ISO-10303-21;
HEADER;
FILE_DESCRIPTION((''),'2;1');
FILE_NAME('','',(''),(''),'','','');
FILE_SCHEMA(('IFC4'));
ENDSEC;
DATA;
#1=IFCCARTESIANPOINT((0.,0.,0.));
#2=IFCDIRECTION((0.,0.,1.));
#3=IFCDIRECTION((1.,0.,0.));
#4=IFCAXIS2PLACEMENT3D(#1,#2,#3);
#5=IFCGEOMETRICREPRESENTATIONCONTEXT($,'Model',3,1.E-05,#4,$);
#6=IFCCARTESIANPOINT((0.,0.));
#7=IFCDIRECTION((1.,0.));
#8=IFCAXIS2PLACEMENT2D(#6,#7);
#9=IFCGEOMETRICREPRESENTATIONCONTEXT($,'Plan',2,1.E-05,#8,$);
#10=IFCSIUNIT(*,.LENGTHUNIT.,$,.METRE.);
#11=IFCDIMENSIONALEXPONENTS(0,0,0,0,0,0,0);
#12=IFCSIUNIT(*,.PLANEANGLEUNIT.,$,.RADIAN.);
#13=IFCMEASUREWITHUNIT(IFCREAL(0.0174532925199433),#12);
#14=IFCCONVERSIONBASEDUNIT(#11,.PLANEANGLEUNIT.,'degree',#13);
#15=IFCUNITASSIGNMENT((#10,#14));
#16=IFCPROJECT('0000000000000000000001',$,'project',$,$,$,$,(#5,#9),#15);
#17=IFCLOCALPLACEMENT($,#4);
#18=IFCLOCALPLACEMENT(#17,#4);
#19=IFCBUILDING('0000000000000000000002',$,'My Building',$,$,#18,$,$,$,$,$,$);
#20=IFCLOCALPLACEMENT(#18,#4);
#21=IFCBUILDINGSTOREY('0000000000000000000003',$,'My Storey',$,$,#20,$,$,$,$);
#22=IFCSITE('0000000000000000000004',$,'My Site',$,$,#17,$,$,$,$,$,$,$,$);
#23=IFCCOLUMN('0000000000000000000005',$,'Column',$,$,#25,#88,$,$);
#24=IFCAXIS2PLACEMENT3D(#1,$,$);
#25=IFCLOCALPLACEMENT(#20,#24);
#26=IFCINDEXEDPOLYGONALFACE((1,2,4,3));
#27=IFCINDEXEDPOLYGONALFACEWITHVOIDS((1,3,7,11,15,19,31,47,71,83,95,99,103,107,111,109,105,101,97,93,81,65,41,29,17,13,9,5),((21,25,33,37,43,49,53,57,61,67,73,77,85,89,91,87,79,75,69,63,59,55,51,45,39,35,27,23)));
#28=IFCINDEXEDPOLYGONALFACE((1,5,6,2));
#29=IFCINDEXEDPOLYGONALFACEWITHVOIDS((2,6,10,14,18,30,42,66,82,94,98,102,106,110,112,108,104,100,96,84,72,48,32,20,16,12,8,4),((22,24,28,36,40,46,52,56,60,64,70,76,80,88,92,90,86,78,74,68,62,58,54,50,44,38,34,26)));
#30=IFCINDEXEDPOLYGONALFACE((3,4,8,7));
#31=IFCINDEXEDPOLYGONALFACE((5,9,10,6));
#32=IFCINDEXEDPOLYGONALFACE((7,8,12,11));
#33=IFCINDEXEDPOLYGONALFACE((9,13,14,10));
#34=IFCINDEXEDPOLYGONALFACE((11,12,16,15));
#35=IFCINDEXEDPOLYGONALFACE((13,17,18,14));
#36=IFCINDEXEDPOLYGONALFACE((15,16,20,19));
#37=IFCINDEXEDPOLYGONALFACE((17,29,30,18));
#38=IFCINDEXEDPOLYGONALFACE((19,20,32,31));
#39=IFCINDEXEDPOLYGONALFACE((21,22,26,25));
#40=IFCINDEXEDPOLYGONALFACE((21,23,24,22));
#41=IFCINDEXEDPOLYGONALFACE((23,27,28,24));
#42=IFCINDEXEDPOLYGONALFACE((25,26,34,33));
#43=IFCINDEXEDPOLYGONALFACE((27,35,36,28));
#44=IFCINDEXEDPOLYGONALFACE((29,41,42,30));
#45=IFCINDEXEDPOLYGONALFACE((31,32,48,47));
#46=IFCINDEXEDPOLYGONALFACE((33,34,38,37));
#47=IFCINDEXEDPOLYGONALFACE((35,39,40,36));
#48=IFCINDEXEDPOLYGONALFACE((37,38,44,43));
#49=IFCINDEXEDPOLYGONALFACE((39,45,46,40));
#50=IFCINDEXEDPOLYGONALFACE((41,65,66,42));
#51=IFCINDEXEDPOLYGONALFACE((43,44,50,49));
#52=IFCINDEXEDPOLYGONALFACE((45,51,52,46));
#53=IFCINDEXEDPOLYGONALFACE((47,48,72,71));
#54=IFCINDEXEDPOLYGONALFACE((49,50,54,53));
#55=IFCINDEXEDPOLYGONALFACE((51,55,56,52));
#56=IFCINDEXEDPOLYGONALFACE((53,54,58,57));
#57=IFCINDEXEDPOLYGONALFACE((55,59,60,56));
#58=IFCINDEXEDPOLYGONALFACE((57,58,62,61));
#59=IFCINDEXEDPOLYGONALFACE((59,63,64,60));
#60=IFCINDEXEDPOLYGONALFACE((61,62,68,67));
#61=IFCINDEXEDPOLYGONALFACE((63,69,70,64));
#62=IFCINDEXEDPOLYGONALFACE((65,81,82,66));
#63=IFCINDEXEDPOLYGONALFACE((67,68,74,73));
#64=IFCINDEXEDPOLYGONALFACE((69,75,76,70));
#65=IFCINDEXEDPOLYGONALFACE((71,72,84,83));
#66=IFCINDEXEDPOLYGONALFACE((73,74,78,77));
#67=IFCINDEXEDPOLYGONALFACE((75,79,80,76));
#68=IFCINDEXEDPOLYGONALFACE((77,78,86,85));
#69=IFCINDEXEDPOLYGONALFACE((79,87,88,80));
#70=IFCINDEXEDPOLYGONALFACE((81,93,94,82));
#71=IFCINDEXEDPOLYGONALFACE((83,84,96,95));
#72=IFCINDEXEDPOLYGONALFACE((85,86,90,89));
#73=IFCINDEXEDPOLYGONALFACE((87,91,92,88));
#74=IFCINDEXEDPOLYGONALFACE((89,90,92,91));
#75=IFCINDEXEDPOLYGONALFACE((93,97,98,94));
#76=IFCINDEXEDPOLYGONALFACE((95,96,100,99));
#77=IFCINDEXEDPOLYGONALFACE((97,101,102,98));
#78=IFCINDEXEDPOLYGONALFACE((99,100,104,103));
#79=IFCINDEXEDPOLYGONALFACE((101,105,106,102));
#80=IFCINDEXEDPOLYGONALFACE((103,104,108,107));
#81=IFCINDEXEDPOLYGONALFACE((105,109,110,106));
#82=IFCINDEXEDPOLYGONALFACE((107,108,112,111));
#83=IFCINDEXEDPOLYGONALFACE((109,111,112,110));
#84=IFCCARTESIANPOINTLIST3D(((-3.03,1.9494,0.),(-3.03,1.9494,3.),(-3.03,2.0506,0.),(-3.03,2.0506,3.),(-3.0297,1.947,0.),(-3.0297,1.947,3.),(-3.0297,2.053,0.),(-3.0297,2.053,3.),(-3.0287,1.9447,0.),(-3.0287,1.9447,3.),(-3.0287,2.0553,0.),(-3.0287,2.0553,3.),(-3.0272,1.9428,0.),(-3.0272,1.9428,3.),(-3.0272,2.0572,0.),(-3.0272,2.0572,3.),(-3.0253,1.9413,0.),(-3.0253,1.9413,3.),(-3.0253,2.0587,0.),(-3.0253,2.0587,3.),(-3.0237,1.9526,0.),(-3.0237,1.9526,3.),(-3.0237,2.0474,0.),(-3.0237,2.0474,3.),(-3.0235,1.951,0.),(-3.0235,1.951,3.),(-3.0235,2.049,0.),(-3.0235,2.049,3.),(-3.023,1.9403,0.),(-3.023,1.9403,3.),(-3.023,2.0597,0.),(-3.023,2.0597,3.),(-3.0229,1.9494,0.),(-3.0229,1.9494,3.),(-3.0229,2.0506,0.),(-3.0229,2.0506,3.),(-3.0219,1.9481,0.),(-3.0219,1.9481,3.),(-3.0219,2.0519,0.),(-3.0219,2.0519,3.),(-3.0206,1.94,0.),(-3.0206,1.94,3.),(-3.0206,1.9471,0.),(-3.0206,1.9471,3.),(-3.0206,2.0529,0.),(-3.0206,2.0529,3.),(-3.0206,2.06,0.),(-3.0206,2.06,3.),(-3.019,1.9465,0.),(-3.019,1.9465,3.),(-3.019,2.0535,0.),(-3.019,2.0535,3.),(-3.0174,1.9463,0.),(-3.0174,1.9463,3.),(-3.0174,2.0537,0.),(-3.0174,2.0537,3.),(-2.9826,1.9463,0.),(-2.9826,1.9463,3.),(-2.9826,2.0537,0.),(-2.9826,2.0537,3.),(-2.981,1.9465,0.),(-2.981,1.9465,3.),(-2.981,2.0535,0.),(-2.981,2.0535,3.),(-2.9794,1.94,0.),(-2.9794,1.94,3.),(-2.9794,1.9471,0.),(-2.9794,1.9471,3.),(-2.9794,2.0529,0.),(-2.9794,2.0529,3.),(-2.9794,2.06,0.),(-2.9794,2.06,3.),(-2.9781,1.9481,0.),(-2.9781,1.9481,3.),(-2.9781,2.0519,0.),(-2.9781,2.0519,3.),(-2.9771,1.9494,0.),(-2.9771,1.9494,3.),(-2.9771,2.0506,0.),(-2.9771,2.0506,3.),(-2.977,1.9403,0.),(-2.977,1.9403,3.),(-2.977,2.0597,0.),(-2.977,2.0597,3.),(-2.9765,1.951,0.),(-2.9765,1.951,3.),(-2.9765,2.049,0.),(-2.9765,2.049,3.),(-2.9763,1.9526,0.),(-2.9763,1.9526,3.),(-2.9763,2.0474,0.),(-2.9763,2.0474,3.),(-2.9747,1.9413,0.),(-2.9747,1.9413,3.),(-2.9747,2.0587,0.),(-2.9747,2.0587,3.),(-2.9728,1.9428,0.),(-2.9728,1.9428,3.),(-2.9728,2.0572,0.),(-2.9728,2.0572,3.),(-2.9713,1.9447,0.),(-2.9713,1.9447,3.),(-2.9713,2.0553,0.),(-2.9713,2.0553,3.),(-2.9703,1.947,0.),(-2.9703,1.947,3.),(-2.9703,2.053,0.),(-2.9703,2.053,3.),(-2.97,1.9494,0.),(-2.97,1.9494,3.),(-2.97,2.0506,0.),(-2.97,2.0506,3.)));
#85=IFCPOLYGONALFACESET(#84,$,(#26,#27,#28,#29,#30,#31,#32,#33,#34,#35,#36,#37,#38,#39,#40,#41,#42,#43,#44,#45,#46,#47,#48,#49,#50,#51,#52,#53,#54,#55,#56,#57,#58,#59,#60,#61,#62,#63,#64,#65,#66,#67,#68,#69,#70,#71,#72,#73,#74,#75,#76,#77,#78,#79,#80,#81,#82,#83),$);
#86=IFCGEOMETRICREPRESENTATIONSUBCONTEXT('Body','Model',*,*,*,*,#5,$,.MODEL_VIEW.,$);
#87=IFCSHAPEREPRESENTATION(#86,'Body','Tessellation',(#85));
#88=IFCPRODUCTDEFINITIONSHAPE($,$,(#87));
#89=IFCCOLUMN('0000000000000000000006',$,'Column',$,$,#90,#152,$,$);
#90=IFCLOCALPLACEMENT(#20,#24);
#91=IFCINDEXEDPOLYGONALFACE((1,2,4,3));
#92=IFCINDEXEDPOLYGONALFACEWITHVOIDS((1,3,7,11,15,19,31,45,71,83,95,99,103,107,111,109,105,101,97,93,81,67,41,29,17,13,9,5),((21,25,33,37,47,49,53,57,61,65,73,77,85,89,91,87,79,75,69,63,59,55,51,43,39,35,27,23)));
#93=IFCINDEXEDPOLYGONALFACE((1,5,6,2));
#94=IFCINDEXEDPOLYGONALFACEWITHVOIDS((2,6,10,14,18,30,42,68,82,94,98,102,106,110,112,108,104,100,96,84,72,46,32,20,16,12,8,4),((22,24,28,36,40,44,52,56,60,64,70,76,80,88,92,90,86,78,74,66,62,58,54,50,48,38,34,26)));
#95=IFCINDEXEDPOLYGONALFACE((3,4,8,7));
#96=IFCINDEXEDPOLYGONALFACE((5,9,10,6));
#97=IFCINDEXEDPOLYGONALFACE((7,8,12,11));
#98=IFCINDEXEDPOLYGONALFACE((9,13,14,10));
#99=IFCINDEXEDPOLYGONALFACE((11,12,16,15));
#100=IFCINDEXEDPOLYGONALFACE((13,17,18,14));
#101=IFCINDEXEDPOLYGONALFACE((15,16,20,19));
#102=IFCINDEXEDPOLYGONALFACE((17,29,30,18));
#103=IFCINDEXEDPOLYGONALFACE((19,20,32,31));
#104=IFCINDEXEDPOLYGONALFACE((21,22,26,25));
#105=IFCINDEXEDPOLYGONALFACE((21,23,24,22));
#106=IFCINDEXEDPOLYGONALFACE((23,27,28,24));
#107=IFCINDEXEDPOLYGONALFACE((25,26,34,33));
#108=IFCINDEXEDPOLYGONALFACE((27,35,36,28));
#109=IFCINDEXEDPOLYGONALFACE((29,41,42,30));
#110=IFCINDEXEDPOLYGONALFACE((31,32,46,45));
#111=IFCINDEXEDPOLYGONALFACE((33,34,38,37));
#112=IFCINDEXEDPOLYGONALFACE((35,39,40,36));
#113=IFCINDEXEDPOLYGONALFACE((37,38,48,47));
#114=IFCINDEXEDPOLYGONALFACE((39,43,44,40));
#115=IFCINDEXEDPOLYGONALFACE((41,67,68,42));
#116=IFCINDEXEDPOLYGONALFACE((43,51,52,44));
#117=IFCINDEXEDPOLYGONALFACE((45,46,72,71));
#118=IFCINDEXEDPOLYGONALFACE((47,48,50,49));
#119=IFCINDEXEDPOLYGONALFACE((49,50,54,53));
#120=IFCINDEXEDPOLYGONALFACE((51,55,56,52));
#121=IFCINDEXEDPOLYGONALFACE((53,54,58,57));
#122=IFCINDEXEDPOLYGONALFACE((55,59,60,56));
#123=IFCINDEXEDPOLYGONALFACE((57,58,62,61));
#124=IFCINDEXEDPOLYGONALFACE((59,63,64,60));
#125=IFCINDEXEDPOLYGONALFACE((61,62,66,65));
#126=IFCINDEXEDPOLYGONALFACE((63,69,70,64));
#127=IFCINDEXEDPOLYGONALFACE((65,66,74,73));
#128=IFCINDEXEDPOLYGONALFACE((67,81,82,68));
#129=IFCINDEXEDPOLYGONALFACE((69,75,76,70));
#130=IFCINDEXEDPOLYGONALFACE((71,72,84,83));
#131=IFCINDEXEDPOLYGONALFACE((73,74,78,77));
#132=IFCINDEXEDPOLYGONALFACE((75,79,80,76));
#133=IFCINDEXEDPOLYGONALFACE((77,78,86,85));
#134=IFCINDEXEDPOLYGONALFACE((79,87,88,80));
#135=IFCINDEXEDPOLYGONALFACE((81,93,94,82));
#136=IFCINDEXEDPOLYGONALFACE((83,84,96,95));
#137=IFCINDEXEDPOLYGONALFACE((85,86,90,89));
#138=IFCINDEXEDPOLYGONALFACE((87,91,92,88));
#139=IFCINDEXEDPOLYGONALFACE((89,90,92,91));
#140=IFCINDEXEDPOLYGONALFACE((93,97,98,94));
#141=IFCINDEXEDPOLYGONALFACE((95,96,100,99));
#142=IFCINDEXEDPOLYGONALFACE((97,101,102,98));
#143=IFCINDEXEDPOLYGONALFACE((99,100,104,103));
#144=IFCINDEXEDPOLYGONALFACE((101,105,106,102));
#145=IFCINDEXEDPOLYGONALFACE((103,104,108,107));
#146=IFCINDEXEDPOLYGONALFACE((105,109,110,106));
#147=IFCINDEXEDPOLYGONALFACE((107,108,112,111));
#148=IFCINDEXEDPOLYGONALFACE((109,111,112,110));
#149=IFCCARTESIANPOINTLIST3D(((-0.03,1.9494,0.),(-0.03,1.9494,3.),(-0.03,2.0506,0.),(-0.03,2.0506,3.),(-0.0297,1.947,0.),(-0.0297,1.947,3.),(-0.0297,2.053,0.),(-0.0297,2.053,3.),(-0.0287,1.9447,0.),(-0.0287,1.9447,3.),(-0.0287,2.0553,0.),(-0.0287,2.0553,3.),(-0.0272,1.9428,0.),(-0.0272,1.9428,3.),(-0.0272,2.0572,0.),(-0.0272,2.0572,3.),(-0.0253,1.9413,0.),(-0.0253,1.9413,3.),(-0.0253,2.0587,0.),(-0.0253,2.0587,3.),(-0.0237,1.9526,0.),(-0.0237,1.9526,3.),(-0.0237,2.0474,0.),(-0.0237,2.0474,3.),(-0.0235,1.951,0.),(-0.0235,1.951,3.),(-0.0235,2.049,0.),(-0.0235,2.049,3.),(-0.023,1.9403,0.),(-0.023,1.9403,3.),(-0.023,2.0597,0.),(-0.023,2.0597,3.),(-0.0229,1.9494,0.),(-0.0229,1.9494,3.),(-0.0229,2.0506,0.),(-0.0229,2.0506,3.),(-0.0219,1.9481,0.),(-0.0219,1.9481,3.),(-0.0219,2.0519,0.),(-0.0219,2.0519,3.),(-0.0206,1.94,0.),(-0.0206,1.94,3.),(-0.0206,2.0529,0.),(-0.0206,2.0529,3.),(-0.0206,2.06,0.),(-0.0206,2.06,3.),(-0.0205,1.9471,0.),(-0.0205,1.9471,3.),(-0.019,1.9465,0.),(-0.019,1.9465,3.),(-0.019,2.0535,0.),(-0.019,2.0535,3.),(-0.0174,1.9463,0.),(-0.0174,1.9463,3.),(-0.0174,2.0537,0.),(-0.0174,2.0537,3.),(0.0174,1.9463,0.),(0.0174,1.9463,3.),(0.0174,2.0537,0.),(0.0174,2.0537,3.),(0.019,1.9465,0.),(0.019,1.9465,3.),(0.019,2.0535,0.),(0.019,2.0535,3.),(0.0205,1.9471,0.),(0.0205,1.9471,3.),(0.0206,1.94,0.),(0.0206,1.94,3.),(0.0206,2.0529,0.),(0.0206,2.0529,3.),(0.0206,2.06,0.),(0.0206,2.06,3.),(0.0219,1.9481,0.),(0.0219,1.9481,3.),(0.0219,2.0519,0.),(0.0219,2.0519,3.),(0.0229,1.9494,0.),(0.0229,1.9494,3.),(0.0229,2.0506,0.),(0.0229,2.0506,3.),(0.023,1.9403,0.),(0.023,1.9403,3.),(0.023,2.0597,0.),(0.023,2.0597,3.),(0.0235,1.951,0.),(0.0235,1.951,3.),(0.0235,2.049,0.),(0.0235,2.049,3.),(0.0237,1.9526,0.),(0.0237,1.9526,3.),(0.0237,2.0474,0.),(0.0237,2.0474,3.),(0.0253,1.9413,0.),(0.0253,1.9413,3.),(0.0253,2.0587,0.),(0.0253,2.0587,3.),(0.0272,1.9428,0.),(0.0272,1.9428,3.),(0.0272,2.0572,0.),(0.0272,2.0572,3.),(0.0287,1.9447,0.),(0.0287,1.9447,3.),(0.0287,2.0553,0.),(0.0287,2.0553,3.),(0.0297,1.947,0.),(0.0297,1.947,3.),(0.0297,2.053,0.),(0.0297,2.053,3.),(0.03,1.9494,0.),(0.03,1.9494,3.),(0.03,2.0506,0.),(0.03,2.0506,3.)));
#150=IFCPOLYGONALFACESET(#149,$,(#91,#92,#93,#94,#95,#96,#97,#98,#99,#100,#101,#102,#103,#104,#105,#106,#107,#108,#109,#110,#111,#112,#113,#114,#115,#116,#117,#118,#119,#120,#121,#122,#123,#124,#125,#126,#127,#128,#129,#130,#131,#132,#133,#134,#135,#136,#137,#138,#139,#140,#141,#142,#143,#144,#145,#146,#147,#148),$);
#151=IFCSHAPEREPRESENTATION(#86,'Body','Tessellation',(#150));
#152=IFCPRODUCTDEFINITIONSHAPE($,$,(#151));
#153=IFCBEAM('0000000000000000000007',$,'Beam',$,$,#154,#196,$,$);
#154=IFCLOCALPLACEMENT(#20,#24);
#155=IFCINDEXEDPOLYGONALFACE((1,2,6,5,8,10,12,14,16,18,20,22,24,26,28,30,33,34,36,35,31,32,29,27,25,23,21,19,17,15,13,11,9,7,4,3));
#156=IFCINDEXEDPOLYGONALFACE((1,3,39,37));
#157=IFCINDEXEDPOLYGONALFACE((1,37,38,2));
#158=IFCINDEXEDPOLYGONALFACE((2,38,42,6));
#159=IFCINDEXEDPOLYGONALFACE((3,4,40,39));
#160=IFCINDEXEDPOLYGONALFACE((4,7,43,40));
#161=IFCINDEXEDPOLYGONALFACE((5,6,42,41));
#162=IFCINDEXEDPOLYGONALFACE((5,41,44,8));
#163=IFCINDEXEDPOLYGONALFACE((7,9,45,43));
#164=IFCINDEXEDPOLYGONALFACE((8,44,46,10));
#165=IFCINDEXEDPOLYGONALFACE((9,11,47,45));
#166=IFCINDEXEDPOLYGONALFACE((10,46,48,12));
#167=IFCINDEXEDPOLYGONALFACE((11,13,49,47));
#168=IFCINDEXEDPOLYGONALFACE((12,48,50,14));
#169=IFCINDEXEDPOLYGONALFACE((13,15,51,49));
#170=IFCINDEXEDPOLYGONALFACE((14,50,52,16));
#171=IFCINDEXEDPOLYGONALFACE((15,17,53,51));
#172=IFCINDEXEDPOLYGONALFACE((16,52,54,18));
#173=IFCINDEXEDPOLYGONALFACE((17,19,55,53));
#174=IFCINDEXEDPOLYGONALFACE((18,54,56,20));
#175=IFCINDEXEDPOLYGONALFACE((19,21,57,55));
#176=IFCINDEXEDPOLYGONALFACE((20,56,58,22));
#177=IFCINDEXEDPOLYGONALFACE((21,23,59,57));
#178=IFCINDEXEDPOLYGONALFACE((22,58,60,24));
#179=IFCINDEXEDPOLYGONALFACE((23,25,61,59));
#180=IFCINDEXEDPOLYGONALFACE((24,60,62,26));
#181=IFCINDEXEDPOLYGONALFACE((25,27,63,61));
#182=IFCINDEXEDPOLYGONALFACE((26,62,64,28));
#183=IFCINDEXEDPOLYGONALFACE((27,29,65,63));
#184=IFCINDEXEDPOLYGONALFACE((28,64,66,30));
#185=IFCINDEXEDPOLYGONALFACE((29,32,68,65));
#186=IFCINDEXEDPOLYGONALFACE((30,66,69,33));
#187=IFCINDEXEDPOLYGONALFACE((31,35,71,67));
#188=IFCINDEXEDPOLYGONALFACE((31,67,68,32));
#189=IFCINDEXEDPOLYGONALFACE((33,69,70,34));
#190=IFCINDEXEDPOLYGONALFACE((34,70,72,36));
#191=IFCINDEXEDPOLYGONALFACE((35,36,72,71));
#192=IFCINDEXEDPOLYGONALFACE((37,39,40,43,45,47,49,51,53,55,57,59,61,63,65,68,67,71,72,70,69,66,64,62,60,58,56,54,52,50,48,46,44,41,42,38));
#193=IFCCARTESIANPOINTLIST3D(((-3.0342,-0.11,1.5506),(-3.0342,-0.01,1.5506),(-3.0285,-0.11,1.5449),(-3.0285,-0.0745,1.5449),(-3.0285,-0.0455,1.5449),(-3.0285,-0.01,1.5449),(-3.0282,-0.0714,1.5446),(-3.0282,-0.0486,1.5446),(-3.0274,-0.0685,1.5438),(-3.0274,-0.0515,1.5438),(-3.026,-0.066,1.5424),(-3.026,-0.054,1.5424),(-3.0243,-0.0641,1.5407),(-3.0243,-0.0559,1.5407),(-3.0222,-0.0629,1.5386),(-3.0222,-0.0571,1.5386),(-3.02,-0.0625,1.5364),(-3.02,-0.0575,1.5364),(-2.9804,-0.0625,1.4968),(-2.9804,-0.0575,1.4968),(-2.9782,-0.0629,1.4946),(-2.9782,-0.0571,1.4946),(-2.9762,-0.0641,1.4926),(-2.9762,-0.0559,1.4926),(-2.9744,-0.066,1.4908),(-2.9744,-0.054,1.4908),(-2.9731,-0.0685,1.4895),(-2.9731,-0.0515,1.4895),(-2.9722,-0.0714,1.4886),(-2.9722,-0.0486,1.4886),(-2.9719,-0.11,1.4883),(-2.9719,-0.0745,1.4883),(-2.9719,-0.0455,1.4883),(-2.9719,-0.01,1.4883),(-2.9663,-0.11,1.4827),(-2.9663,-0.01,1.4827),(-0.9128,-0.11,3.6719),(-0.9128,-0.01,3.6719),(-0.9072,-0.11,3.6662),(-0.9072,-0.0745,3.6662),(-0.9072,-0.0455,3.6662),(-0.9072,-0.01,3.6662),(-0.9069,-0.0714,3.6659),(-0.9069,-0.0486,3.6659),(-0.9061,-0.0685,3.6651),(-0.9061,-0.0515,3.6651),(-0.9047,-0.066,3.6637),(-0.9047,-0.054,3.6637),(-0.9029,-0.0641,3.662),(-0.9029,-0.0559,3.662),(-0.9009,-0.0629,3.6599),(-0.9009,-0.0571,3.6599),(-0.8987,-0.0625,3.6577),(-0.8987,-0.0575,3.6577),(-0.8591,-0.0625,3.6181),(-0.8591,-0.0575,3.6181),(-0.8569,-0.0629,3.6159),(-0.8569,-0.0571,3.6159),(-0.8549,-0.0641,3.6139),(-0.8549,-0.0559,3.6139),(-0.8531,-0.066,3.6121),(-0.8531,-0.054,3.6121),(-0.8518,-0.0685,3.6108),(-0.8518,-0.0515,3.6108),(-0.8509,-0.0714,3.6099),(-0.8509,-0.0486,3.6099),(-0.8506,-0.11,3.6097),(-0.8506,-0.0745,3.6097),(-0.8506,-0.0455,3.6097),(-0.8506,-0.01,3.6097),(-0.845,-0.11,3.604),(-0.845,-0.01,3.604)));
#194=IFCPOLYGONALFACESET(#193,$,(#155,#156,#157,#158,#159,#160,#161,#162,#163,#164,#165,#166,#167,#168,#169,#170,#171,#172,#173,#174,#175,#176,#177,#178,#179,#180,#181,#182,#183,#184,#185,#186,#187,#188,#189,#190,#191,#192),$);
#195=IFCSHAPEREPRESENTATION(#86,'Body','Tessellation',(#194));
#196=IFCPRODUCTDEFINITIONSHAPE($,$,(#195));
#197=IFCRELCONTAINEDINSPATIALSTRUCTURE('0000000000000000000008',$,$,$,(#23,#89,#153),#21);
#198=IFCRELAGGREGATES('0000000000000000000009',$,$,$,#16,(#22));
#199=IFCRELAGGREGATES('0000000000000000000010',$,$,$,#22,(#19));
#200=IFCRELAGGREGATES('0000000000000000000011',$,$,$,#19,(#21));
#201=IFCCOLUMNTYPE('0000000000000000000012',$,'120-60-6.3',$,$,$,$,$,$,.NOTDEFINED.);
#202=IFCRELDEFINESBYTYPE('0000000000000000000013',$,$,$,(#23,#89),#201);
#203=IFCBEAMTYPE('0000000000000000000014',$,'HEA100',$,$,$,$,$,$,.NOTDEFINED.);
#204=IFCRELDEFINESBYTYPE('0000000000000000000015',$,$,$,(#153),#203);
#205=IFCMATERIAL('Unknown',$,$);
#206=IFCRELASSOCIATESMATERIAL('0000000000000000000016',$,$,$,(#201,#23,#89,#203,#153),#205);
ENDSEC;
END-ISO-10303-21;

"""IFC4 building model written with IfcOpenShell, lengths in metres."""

from ifc_helpers import new_model, entity, si_unit, converted_unit, frame, origin_with_axes, origin_2d_with_axis, place, context, subcontext, project, spatial, hollow_rectangle, i_section, extrude, material, material_profile, profile_set, profile_usage, type_object, element, save


model = new_model("IFC4")

# Units and contexts
model_context = context("Model", 3, precision=1e-05, world=origin_with_axes())
plan_context = context("Plan", 2, precision=1e-05, world=origin_2d_with_axis())
body_context = subcontext(model_context, "Body", "Model", "MODEL_VIEW")
ifc_project = project(units=[si_unit("LENGTHUNIT", "METRE"), converted_unit("PLANEANGLEUNIT", "degree", entity("IfcReal", 0.0174532925199433), si_unit("PLANEANGLEUNIT", "RADIAN"), dimensions=[0, 0, 0, 0, 0, 0, 0])], contexts=[model_context, plan_context])

# Site, building, storey
site_placement = place(None, origin_with_axes())
site = spatial("IfcSite", under=ifc_project, at=site_placement, Name="My Site")
building_placement = place(site_placement, origin_with_axes())
building = spatial("IfcBuilding", under=site, at=building_placement, Name="My Building")
storey_placement = place(building_placement, origin_with_axes())
storey = spatial("IfcBuildingStorey", under=building, at=storey_placement, Name="My Storey")

# Shared definitions
ifc_material = material(Name="Unknown")

# Columns
ifc_material_profile_1 = material_profile(ifc_material, hollow_rectangle(XDim=0.06, YDim=0.12, WallThickness=0.0063, InnerFilletRadius=0.0063, OuterFilletRadius=0.0095))
ifc_profile_set_1 = profile_set([ifc_material_profile_1])
column_type = type_object("IfcColumnType", Name="120-60-6.3", PredefinedType="NOTDEFINED", material=ifc_profile_set_1)
ifc_profile_usage_1 = profile_usage(ifc_profile_set_1, cardinal=5)
column_1_placement = place(storey_placement, frame((-3.0, 2.0, 0.0), z_axis=(0.0, 0.0, 1.0), x_axis=(1.0, 0.0, 0.0)))
element("IfcColumn", 1, at=column_1_placement, inside=storey, type_object=column_type, material=ifc_profile_usage_1, Name="Column", context=body_context, shape_type="SweptSolid", body=[
    extrude(hollow_rectangle(XDim=0.06, YDim=0.12, WallThickness=0.0063, InnerFilletRadius=0.0063, OuterFilletRadius=0.0095), origin_with_axes(), (0.0, 0.0, 1.0), 3.0),
])
ifc_profile_usage_2 = profile_usage(ifc_profile_set_1, cardinal=5)
column_2_placement = place(storey_placement, frame((0.0, 2.0, 0.0), z_axis=(0.0, 0.0, 1.0), x_axis=(1.0, 0.0, 0.0)))
element("IfcColumn", 2, at=column_2_placement, inside=storey, type_object=column_type, material=ifc_profile_usage_2, Name="Column", context=body_context, shape_type="SweptSolid", body=[
    extrude(hollow_rectangle(XDim=0.06, YDim=0.12, WallThickness=0.0063, InnerFilletRadius=0.0063, OuterFilletRadius=0.0095), origin_with_axes(), (0.0, 0.0, 1.0), 3.0),
])

# Beam
ifc_material_profile_2 = material_profile(ifc_material, i_section(OverallWidth=0.1, OverallDepth=0.096, WebThickness=0.005, FlangeThickness=0.008, FilletRadius=0.012))
ifc_profile_set_2 = profile_set([ifc_material_profile_2])
ifc_profile_usage_3 = profile_usage(ifc_profile_set_2, cardinal=5)
beam_type_1 = type_object("IfcBeamType", Name="HEA100", PredefinedType="NOTDEFINED", material=ifc_profile_set_2)
beam_1_placement = place(storey_placement, frame((-3.0002, -0.06, 1.5166), z_axis=(0.707107, 0.0, 0.707107), x_axis=(0.0, 1.0, 0.0)))
element("IfcBeam", 3, at=beam_1_placement, inside=storey, type_object=beam_type_1, material=ifc_profile_usage_3, Name="Beam", context=body_context, shape_type="SweptSolid", body=[
    extrude(i_section(OverallWidth=0.1, OverallDepth=0.096, WebThickness=0.005, FlangeThickness=0.008, FilletRadius=0.012), origin_with_axes(), (0.0, 0.0, 1.0), 3.0),
])

save(model, "model.ifc")
